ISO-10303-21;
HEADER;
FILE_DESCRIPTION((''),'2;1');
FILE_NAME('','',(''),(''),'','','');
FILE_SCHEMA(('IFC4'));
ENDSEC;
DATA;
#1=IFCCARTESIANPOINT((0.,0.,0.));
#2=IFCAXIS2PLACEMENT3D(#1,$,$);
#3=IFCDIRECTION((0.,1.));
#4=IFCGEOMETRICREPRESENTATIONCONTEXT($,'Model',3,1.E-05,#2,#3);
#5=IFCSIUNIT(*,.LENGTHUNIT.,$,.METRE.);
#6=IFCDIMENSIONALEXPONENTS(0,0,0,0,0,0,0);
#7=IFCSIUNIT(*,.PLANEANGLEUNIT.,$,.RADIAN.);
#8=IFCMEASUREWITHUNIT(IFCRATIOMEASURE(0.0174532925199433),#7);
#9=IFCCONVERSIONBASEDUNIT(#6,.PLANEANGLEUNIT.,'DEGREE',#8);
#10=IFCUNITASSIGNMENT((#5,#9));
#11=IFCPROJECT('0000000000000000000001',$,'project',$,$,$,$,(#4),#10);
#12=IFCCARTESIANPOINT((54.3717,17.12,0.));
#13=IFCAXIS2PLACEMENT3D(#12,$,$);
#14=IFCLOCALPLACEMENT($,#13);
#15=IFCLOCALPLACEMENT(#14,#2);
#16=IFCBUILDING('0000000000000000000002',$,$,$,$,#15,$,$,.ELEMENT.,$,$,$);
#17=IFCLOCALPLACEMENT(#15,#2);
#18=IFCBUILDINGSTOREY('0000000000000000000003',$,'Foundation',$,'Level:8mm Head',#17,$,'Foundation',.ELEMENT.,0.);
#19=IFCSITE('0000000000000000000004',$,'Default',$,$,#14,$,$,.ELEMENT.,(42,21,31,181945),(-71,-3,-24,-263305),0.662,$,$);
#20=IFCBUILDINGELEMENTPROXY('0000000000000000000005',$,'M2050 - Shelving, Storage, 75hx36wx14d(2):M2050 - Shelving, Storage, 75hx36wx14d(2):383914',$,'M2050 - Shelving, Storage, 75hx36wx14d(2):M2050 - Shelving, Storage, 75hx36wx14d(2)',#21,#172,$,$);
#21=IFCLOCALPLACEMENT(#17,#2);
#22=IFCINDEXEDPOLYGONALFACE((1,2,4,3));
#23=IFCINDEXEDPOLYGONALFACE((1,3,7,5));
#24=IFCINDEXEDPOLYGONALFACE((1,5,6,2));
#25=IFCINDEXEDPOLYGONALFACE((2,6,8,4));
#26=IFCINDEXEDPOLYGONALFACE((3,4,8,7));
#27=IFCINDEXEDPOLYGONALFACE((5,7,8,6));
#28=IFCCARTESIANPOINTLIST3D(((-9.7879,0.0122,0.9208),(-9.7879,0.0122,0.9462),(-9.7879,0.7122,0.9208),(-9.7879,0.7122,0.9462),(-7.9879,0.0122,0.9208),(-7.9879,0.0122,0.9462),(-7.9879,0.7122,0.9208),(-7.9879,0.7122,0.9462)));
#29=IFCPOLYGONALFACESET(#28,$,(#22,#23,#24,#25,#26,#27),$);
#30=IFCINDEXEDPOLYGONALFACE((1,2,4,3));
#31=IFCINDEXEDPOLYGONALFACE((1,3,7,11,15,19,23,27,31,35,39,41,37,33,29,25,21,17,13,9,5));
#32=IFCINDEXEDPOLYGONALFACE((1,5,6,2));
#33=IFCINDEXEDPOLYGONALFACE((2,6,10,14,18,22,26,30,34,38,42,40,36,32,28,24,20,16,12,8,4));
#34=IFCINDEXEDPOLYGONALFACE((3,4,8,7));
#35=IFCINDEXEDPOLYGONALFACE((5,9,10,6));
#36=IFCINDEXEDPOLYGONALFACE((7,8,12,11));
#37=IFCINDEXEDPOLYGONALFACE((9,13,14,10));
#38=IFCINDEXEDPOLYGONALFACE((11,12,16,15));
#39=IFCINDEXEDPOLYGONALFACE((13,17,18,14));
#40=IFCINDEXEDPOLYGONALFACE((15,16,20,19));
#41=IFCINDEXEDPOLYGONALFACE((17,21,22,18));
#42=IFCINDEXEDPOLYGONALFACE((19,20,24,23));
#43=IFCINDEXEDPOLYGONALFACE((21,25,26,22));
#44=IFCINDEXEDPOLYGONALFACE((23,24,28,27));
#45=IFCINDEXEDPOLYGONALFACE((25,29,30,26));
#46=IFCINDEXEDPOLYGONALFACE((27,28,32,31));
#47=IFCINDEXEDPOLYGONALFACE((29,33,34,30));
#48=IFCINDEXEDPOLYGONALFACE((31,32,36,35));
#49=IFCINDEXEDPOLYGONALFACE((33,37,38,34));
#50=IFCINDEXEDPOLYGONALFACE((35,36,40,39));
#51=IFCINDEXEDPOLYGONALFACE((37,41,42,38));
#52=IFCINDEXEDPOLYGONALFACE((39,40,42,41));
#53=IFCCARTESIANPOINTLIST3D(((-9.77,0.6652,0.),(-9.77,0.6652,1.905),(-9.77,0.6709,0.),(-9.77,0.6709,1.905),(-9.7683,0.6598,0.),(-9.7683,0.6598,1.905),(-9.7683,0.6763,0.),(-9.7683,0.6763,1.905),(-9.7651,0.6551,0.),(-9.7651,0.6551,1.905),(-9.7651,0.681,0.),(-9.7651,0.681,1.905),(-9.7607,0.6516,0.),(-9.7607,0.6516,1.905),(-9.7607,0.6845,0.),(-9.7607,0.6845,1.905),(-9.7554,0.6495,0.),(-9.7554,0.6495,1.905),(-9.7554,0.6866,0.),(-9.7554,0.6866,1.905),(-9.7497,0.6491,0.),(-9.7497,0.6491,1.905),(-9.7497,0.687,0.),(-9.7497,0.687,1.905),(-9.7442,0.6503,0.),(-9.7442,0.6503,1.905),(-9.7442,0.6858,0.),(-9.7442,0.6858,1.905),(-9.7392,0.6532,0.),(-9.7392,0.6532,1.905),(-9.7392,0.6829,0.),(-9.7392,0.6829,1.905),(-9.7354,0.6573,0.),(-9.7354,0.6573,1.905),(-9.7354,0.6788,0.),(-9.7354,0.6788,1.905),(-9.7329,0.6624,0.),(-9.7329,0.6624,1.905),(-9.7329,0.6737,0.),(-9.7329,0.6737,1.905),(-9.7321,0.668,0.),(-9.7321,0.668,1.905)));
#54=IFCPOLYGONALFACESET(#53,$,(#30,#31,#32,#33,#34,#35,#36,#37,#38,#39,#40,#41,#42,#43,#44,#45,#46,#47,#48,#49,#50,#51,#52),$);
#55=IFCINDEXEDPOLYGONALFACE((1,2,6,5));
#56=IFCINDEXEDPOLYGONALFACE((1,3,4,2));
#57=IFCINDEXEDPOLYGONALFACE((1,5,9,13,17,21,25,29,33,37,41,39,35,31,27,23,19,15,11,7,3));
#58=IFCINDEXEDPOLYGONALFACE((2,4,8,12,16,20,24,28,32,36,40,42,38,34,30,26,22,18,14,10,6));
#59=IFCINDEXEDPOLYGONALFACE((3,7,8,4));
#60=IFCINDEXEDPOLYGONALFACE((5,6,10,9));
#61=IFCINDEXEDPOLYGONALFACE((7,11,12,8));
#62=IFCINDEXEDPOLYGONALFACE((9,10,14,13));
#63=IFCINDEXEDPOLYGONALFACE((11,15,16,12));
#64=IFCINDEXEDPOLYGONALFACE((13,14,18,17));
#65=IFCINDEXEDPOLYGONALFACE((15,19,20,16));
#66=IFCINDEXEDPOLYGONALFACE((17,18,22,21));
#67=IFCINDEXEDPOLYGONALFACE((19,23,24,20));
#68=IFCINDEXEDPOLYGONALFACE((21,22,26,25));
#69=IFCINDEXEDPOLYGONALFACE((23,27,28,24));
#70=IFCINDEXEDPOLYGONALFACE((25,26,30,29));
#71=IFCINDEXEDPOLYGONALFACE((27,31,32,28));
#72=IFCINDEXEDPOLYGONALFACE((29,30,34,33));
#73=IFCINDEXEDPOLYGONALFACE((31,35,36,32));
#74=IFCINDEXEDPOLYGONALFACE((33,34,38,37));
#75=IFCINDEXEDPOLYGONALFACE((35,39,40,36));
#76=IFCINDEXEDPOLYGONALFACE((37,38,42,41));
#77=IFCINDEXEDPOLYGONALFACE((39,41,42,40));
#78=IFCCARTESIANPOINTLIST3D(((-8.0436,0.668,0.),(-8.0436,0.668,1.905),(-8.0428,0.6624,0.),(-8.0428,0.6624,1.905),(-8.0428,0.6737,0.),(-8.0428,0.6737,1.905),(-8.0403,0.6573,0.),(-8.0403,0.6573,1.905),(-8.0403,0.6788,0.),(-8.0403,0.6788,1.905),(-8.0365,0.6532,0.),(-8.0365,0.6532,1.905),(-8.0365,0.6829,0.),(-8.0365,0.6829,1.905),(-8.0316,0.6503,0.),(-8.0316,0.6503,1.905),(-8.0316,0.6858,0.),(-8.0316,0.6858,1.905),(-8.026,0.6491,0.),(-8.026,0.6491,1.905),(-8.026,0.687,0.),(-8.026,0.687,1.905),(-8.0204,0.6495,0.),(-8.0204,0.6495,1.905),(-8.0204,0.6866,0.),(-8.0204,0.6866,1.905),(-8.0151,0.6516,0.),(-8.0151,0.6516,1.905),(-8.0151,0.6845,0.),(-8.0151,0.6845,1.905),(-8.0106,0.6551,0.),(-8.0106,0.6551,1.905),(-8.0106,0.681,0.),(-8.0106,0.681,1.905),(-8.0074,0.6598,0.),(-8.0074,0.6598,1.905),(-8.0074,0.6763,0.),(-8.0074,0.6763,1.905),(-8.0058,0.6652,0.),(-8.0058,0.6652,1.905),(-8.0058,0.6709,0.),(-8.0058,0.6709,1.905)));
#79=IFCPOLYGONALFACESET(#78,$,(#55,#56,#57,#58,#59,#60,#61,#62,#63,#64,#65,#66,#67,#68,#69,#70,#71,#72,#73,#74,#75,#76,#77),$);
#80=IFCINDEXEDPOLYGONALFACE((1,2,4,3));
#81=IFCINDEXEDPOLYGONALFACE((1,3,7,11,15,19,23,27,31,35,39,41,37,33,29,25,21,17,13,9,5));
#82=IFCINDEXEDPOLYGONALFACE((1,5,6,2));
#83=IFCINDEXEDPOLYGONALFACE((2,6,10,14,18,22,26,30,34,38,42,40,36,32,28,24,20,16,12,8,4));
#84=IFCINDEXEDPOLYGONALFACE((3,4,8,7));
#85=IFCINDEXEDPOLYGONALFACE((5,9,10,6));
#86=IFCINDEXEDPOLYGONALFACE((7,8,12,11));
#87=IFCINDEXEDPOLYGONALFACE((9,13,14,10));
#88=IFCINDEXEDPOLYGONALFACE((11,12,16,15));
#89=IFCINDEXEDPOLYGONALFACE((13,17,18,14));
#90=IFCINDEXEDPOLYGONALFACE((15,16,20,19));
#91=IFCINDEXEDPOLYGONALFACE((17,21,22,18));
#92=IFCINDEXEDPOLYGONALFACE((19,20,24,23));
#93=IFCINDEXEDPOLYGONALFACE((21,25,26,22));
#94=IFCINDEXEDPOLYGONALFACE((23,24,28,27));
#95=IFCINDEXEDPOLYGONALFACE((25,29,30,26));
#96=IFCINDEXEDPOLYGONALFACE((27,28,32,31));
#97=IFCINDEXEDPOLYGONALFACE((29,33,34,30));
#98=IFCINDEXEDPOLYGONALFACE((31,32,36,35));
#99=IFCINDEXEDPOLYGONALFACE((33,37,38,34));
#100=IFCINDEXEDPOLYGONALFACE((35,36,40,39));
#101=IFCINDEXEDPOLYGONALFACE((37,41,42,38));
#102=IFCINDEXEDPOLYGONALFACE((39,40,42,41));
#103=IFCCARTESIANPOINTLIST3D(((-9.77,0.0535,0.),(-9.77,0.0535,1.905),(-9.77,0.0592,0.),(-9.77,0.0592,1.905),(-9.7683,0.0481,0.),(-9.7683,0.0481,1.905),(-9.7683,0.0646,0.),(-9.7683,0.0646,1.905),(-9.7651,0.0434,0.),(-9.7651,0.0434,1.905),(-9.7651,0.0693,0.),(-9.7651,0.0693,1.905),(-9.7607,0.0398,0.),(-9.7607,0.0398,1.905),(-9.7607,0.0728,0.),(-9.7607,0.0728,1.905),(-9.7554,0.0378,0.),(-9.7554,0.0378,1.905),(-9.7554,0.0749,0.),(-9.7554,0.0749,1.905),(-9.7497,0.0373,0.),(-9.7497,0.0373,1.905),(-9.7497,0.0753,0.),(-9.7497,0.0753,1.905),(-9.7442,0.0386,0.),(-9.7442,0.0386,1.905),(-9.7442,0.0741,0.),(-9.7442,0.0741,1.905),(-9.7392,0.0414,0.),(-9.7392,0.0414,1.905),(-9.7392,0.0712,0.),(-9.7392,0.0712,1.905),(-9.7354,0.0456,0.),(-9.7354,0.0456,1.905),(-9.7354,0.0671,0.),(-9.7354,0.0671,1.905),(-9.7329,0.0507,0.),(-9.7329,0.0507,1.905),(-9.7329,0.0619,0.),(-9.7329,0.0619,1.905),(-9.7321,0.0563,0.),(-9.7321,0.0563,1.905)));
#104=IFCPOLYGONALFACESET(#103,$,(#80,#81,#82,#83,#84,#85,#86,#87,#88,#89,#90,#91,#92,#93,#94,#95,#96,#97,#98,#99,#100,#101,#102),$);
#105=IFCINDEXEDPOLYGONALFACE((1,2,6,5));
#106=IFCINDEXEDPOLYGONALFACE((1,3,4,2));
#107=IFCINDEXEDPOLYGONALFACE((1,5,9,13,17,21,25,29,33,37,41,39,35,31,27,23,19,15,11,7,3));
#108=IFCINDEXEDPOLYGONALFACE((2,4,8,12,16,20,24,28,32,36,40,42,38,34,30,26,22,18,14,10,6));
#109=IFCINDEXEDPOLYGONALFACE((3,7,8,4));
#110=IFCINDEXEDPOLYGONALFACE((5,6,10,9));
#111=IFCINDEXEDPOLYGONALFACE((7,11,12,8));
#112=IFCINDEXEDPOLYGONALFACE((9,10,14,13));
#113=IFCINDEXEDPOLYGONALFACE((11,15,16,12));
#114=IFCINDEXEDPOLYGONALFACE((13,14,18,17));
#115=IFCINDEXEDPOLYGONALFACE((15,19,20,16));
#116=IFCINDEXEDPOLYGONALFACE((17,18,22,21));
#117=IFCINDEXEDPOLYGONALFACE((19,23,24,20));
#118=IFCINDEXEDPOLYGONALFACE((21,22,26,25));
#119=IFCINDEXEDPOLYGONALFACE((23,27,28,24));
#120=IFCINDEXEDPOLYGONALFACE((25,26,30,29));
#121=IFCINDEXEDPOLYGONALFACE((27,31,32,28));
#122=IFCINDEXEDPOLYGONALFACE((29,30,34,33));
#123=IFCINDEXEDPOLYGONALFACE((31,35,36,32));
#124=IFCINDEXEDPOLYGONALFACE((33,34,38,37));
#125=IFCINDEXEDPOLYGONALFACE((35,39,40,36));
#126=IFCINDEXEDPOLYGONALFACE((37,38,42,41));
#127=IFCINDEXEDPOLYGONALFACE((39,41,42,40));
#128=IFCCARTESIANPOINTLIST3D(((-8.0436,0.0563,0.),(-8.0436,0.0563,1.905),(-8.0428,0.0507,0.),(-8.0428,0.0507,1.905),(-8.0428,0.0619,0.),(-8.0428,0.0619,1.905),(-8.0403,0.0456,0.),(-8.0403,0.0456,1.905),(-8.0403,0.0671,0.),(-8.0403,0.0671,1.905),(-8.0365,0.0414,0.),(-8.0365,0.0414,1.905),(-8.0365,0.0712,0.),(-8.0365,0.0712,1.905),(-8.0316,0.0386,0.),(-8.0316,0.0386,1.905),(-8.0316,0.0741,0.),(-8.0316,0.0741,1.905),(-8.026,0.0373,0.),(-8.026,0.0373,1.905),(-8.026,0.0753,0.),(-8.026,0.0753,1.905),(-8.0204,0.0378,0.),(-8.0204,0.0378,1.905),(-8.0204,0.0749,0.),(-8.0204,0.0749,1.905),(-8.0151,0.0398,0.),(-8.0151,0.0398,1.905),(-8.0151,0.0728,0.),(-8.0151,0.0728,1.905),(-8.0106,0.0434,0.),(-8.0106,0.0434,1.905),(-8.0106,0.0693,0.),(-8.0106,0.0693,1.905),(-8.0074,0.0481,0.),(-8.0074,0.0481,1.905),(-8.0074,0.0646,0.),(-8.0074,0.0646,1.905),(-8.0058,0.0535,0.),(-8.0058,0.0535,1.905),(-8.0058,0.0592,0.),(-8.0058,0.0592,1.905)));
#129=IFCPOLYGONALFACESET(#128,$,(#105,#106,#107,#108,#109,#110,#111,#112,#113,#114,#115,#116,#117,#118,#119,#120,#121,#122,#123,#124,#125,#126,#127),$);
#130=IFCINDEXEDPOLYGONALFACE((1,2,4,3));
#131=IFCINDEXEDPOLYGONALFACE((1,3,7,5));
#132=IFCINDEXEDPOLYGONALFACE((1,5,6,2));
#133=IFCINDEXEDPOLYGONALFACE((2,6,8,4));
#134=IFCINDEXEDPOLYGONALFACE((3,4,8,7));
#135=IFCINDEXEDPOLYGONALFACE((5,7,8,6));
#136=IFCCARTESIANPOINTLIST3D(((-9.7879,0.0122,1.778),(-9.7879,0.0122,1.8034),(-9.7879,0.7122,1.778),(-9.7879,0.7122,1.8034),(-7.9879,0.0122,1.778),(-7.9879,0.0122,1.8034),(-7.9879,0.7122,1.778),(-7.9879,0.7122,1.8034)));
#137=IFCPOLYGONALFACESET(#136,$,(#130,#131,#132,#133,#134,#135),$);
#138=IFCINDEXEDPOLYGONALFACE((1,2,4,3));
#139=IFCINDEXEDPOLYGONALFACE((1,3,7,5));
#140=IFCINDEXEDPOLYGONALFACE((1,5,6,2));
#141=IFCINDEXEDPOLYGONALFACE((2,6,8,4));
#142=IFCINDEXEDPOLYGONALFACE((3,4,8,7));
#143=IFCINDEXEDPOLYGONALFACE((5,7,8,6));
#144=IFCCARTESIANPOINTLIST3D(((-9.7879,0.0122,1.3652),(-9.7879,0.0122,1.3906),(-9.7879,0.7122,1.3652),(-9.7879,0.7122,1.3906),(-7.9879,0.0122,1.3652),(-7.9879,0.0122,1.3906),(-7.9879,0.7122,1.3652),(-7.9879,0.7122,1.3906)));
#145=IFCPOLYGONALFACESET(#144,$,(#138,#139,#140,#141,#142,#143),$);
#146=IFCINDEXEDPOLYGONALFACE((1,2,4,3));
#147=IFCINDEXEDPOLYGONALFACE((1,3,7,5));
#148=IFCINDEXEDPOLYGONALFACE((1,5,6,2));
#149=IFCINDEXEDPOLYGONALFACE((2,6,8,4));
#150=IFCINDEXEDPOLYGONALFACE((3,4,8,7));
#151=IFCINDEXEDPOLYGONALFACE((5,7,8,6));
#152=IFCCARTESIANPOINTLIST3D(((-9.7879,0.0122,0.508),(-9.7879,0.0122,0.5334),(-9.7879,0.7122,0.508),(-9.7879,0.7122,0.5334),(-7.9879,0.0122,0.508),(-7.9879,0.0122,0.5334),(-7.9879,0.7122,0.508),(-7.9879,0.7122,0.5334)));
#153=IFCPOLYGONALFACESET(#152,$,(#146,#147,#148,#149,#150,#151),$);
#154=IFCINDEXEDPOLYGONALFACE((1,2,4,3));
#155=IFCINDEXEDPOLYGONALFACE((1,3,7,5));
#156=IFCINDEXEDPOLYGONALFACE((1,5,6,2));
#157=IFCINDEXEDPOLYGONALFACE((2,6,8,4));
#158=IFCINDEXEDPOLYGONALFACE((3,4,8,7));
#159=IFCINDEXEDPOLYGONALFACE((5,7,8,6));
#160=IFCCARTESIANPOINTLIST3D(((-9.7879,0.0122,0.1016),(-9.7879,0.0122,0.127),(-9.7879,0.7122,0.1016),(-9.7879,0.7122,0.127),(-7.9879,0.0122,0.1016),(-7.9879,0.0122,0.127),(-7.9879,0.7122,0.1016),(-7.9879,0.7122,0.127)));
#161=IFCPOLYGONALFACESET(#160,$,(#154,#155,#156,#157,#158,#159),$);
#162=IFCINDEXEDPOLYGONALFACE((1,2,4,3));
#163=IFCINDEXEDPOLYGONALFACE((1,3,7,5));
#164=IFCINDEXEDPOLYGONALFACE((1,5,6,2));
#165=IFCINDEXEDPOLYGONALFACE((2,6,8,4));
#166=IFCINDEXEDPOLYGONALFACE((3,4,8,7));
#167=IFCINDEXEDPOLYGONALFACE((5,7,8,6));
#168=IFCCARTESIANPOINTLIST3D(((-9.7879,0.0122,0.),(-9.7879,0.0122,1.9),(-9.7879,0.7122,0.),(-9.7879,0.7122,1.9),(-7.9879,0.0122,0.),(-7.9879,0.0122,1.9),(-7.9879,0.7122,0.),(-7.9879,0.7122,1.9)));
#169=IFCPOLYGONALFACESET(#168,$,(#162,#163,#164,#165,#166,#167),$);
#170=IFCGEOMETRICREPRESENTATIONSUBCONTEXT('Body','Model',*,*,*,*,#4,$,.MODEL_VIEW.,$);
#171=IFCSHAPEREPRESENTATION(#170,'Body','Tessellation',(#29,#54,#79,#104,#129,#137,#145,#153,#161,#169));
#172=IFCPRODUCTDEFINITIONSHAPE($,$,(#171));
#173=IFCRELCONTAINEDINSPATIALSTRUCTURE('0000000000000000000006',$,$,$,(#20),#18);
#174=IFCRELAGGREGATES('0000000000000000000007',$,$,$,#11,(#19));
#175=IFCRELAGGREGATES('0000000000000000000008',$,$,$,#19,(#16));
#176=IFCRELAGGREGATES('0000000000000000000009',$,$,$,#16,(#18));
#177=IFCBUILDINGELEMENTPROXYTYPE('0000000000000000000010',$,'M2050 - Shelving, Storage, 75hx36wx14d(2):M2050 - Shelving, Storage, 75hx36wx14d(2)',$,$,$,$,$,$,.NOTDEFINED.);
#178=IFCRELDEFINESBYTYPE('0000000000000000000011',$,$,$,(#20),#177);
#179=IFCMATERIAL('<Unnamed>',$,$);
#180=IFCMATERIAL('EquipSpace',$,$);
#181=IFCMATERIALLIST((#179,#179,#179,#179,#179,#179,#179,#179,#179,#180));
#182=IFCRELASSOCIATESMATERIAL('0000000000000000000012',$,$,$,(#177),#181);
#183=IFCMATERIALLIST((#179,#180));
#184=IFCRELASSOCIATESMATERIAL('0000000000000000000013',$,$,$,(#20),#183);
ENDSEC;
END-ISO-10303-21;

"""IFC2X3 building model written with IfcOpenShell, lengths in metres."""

from ifc_helpers import new_model, entity, si_unit, converted_unit, direction, frame, frame_2d, origin, origin_2d_with_axis, place, context, subcontext, project, spatial, rectangle, circle, extrude, source, transform, mapped, material, material_list, type_object, type_shapes, element, save


model = new_model("IFC2X3")

# Units and contexts
model_context = context("Model", 3, precision=1e-05, world=origin(), true_north=direction((0.0, 1.0)))
body_context = subcontext(model_context, "Body", "Model", "MODEL_VIEW")
ifc_project = project(units=[si_unit("LENGTHUNIT", "METRE"), converted_unit("PLANEANGLEUNIT", "DEGREE", entity("IfcRatioMeasure", 0.0174532925199433), si_unit("PLANEANGLEUNIT", "RADIAN"), dimensions=[0, 0, 0, 0, 0, 0, 0])], contexts=[model_context])

# Site, building, storey
site_placement = place(None, frame((54.3717, 17.12, 0.0)))
site = spatial("IfcSite", under=ifc_project, at=site_placement, Name="Default", CompositionType="ELEMENT", RefLatitude=(42, 21, 31, 181945), RefLongitude=(-71, -3, -24, -263305), RefElevation=0.662)
building_placement = place(site_placement, origin())
building = spatial("IfcBuilding", under=site, at=building_placement, CompositionType="ELEMENT")
storey_placement = place(building_placement, origin())
storey = spatial("IfcBuildingStorey", under=building, at=storey_placement, Name="Foundation", ObjectType="Level:8mm Head", LongName="Foundation", CompositionType="ELEMENT", Elevation=0.0)

# Building element proxy
ifc_material_1 = material(Name="<Unnamed>")
ifc_material_2 = material(Name="EquipSpace")
ifc_material_list_1 = material_list([ifc_material_1, ifc_material_1, ifc_material_1, ifc_material_1, ifc_material_1, ifc_material_1, ifc_material_1, ifc_material_1, ifc_material_1, ifc_material_2])
building_element_proxy_type = type_object("IfcBuildingElementProxyType", Name="M2050 - Shelving, Storage, 75hx36wx14d(2):M2050 - Shelving, Storage, 75hx36wx14d(2)", PredefinedType="NOTDEFINED", material=ifc_material_list_1)
shared_shape = source(origin(), body_context, "Body", "SweptSolid", [
    extrude(rectangle(XDim=1.8, YDim=0.7, at=origin_2d_with_axis()), frame((0.0, 0.0, 0.9207), z_axis=(0.0, 0.0, 1.0), x_axis=(-1.0, 0.0, 0.0)), (0.0, 0.0, 1.0), 0.0254),
    extrude(circle(Radius=0.0191, at=origin_2d_with_axis()), frame((0.8633, -0.3059, 0.0), z_axis=(0.0, 0.0, 1.0), x_axis=(-1.0, 0.0, 0.0)), (0.0, 0.0, 1.0), 1.905),
    extrude(circle(Radius=0.0191, at=origin_2d_with_axis()), frame((-0.8633, -0.3059, 0.0)), (0.0, 0.0, 1.0), 1.905),
    extrude(circle(Radius=0.0191, at=origin_2d_with_axis()), frame((0.8633, 0.3059, 0.0), z_axis=(0.0, 0.0, 1.0), x_axis=(-1.0, 0.0, 0.0)), (0.0, 0.0, 1.0), 1.905),
    extrude(circle(Radius=0.0191, at=origin_2d_with_axis()), frame((-0.8633, 0.3059, 0.0)), (0.0, 0.0, 1.0), 1.905),
    extrude(rectangle(XDim=1.8, YDim=0.7, at=origin_2d_with_axis()), frame((0.0, 0.0, 1.778), z_axis=(0.0, 0.0, 1.0), x_axis=(-1.0, 0.0, 0.0)), (0.0, 0.0, 1.0), 0.0254),
    extrude(rectangle(XDim=1.8, YDim=0.7, at=origin_2d_with_axis()), frame((0.0, 0.0, 1.3653), z_axis=(0.0, 0.0, 1.0), x_axis=(-1.0, 0.0, 0.0)), (0.0, 0.0, 1.0), 0.0254),
    extrude(rectangle(XDim=1.8, YDim=0.7, at=origin_2d_with_axis()), frame((0.0, 0.0, 0.508), z_axis=(0.0, 0.0, 1.0), x_axis=(-1.0, 0.0, 0.0)), (0.0, 0.0, 1.0), 0.0254),
    extrude(rectangle(XDim=1.8, YDim=0.7, at=origin_2d_with_axis()), frame((0.0, 0.0, 0.1016), z_axis=(0.0, 0.0, 1.0), x_axis=(-1.0, 0.0, 0.0)), (0.0, 0.0, 1.0), 0.0254),
    extrude(rectangle(XDim=0.7, YDim=1.8, at=frame_2d((0.0, 0.18), x_axis=(1.0, 0.0))), frame((-0.18, 0.0, 0.0), z_axis=(0.0, 0.0, 1.0), x_axis=(0.0, -1.0, 0.0)), (0.0, 0.0, 1.0), 1.9),
])
type_shapes(building_element_proxy_type, [shared_shape])
ifc_material_list_2 = material_list([ifc_material_1, ifc_material_2])
proxy_1_placement = place(storey_placement, frame((-8.8879, 0.3622, 0.0), z_axis=(0.0, 0.0, 1.0), x_axis=(-1.0, 0.0, 0.0)))
element("IfcBuildingElementProxy", 1, at=proxy_1_placement, inside=storey, type_object=building_element_proxy_type, material=ifc_material_list_2, Name="M2050 - Shelving, Storage, 75hx36wx14d(2):M2050 - Shelving, Storage, 75hx36wx14d(2):383914", ObjectType="M2050 - Shelving, Storage, 75hx36wx14d(2):M2050 - Shelving, Storage, 75hx36wx14d(2)", context=body_context, shape_type="MappedRepresentation", body=[
    mapped(shared_shape, transform((0.0, 0.0, 0.0), scale=1.0)),
])

save(model, "model.ifc")
